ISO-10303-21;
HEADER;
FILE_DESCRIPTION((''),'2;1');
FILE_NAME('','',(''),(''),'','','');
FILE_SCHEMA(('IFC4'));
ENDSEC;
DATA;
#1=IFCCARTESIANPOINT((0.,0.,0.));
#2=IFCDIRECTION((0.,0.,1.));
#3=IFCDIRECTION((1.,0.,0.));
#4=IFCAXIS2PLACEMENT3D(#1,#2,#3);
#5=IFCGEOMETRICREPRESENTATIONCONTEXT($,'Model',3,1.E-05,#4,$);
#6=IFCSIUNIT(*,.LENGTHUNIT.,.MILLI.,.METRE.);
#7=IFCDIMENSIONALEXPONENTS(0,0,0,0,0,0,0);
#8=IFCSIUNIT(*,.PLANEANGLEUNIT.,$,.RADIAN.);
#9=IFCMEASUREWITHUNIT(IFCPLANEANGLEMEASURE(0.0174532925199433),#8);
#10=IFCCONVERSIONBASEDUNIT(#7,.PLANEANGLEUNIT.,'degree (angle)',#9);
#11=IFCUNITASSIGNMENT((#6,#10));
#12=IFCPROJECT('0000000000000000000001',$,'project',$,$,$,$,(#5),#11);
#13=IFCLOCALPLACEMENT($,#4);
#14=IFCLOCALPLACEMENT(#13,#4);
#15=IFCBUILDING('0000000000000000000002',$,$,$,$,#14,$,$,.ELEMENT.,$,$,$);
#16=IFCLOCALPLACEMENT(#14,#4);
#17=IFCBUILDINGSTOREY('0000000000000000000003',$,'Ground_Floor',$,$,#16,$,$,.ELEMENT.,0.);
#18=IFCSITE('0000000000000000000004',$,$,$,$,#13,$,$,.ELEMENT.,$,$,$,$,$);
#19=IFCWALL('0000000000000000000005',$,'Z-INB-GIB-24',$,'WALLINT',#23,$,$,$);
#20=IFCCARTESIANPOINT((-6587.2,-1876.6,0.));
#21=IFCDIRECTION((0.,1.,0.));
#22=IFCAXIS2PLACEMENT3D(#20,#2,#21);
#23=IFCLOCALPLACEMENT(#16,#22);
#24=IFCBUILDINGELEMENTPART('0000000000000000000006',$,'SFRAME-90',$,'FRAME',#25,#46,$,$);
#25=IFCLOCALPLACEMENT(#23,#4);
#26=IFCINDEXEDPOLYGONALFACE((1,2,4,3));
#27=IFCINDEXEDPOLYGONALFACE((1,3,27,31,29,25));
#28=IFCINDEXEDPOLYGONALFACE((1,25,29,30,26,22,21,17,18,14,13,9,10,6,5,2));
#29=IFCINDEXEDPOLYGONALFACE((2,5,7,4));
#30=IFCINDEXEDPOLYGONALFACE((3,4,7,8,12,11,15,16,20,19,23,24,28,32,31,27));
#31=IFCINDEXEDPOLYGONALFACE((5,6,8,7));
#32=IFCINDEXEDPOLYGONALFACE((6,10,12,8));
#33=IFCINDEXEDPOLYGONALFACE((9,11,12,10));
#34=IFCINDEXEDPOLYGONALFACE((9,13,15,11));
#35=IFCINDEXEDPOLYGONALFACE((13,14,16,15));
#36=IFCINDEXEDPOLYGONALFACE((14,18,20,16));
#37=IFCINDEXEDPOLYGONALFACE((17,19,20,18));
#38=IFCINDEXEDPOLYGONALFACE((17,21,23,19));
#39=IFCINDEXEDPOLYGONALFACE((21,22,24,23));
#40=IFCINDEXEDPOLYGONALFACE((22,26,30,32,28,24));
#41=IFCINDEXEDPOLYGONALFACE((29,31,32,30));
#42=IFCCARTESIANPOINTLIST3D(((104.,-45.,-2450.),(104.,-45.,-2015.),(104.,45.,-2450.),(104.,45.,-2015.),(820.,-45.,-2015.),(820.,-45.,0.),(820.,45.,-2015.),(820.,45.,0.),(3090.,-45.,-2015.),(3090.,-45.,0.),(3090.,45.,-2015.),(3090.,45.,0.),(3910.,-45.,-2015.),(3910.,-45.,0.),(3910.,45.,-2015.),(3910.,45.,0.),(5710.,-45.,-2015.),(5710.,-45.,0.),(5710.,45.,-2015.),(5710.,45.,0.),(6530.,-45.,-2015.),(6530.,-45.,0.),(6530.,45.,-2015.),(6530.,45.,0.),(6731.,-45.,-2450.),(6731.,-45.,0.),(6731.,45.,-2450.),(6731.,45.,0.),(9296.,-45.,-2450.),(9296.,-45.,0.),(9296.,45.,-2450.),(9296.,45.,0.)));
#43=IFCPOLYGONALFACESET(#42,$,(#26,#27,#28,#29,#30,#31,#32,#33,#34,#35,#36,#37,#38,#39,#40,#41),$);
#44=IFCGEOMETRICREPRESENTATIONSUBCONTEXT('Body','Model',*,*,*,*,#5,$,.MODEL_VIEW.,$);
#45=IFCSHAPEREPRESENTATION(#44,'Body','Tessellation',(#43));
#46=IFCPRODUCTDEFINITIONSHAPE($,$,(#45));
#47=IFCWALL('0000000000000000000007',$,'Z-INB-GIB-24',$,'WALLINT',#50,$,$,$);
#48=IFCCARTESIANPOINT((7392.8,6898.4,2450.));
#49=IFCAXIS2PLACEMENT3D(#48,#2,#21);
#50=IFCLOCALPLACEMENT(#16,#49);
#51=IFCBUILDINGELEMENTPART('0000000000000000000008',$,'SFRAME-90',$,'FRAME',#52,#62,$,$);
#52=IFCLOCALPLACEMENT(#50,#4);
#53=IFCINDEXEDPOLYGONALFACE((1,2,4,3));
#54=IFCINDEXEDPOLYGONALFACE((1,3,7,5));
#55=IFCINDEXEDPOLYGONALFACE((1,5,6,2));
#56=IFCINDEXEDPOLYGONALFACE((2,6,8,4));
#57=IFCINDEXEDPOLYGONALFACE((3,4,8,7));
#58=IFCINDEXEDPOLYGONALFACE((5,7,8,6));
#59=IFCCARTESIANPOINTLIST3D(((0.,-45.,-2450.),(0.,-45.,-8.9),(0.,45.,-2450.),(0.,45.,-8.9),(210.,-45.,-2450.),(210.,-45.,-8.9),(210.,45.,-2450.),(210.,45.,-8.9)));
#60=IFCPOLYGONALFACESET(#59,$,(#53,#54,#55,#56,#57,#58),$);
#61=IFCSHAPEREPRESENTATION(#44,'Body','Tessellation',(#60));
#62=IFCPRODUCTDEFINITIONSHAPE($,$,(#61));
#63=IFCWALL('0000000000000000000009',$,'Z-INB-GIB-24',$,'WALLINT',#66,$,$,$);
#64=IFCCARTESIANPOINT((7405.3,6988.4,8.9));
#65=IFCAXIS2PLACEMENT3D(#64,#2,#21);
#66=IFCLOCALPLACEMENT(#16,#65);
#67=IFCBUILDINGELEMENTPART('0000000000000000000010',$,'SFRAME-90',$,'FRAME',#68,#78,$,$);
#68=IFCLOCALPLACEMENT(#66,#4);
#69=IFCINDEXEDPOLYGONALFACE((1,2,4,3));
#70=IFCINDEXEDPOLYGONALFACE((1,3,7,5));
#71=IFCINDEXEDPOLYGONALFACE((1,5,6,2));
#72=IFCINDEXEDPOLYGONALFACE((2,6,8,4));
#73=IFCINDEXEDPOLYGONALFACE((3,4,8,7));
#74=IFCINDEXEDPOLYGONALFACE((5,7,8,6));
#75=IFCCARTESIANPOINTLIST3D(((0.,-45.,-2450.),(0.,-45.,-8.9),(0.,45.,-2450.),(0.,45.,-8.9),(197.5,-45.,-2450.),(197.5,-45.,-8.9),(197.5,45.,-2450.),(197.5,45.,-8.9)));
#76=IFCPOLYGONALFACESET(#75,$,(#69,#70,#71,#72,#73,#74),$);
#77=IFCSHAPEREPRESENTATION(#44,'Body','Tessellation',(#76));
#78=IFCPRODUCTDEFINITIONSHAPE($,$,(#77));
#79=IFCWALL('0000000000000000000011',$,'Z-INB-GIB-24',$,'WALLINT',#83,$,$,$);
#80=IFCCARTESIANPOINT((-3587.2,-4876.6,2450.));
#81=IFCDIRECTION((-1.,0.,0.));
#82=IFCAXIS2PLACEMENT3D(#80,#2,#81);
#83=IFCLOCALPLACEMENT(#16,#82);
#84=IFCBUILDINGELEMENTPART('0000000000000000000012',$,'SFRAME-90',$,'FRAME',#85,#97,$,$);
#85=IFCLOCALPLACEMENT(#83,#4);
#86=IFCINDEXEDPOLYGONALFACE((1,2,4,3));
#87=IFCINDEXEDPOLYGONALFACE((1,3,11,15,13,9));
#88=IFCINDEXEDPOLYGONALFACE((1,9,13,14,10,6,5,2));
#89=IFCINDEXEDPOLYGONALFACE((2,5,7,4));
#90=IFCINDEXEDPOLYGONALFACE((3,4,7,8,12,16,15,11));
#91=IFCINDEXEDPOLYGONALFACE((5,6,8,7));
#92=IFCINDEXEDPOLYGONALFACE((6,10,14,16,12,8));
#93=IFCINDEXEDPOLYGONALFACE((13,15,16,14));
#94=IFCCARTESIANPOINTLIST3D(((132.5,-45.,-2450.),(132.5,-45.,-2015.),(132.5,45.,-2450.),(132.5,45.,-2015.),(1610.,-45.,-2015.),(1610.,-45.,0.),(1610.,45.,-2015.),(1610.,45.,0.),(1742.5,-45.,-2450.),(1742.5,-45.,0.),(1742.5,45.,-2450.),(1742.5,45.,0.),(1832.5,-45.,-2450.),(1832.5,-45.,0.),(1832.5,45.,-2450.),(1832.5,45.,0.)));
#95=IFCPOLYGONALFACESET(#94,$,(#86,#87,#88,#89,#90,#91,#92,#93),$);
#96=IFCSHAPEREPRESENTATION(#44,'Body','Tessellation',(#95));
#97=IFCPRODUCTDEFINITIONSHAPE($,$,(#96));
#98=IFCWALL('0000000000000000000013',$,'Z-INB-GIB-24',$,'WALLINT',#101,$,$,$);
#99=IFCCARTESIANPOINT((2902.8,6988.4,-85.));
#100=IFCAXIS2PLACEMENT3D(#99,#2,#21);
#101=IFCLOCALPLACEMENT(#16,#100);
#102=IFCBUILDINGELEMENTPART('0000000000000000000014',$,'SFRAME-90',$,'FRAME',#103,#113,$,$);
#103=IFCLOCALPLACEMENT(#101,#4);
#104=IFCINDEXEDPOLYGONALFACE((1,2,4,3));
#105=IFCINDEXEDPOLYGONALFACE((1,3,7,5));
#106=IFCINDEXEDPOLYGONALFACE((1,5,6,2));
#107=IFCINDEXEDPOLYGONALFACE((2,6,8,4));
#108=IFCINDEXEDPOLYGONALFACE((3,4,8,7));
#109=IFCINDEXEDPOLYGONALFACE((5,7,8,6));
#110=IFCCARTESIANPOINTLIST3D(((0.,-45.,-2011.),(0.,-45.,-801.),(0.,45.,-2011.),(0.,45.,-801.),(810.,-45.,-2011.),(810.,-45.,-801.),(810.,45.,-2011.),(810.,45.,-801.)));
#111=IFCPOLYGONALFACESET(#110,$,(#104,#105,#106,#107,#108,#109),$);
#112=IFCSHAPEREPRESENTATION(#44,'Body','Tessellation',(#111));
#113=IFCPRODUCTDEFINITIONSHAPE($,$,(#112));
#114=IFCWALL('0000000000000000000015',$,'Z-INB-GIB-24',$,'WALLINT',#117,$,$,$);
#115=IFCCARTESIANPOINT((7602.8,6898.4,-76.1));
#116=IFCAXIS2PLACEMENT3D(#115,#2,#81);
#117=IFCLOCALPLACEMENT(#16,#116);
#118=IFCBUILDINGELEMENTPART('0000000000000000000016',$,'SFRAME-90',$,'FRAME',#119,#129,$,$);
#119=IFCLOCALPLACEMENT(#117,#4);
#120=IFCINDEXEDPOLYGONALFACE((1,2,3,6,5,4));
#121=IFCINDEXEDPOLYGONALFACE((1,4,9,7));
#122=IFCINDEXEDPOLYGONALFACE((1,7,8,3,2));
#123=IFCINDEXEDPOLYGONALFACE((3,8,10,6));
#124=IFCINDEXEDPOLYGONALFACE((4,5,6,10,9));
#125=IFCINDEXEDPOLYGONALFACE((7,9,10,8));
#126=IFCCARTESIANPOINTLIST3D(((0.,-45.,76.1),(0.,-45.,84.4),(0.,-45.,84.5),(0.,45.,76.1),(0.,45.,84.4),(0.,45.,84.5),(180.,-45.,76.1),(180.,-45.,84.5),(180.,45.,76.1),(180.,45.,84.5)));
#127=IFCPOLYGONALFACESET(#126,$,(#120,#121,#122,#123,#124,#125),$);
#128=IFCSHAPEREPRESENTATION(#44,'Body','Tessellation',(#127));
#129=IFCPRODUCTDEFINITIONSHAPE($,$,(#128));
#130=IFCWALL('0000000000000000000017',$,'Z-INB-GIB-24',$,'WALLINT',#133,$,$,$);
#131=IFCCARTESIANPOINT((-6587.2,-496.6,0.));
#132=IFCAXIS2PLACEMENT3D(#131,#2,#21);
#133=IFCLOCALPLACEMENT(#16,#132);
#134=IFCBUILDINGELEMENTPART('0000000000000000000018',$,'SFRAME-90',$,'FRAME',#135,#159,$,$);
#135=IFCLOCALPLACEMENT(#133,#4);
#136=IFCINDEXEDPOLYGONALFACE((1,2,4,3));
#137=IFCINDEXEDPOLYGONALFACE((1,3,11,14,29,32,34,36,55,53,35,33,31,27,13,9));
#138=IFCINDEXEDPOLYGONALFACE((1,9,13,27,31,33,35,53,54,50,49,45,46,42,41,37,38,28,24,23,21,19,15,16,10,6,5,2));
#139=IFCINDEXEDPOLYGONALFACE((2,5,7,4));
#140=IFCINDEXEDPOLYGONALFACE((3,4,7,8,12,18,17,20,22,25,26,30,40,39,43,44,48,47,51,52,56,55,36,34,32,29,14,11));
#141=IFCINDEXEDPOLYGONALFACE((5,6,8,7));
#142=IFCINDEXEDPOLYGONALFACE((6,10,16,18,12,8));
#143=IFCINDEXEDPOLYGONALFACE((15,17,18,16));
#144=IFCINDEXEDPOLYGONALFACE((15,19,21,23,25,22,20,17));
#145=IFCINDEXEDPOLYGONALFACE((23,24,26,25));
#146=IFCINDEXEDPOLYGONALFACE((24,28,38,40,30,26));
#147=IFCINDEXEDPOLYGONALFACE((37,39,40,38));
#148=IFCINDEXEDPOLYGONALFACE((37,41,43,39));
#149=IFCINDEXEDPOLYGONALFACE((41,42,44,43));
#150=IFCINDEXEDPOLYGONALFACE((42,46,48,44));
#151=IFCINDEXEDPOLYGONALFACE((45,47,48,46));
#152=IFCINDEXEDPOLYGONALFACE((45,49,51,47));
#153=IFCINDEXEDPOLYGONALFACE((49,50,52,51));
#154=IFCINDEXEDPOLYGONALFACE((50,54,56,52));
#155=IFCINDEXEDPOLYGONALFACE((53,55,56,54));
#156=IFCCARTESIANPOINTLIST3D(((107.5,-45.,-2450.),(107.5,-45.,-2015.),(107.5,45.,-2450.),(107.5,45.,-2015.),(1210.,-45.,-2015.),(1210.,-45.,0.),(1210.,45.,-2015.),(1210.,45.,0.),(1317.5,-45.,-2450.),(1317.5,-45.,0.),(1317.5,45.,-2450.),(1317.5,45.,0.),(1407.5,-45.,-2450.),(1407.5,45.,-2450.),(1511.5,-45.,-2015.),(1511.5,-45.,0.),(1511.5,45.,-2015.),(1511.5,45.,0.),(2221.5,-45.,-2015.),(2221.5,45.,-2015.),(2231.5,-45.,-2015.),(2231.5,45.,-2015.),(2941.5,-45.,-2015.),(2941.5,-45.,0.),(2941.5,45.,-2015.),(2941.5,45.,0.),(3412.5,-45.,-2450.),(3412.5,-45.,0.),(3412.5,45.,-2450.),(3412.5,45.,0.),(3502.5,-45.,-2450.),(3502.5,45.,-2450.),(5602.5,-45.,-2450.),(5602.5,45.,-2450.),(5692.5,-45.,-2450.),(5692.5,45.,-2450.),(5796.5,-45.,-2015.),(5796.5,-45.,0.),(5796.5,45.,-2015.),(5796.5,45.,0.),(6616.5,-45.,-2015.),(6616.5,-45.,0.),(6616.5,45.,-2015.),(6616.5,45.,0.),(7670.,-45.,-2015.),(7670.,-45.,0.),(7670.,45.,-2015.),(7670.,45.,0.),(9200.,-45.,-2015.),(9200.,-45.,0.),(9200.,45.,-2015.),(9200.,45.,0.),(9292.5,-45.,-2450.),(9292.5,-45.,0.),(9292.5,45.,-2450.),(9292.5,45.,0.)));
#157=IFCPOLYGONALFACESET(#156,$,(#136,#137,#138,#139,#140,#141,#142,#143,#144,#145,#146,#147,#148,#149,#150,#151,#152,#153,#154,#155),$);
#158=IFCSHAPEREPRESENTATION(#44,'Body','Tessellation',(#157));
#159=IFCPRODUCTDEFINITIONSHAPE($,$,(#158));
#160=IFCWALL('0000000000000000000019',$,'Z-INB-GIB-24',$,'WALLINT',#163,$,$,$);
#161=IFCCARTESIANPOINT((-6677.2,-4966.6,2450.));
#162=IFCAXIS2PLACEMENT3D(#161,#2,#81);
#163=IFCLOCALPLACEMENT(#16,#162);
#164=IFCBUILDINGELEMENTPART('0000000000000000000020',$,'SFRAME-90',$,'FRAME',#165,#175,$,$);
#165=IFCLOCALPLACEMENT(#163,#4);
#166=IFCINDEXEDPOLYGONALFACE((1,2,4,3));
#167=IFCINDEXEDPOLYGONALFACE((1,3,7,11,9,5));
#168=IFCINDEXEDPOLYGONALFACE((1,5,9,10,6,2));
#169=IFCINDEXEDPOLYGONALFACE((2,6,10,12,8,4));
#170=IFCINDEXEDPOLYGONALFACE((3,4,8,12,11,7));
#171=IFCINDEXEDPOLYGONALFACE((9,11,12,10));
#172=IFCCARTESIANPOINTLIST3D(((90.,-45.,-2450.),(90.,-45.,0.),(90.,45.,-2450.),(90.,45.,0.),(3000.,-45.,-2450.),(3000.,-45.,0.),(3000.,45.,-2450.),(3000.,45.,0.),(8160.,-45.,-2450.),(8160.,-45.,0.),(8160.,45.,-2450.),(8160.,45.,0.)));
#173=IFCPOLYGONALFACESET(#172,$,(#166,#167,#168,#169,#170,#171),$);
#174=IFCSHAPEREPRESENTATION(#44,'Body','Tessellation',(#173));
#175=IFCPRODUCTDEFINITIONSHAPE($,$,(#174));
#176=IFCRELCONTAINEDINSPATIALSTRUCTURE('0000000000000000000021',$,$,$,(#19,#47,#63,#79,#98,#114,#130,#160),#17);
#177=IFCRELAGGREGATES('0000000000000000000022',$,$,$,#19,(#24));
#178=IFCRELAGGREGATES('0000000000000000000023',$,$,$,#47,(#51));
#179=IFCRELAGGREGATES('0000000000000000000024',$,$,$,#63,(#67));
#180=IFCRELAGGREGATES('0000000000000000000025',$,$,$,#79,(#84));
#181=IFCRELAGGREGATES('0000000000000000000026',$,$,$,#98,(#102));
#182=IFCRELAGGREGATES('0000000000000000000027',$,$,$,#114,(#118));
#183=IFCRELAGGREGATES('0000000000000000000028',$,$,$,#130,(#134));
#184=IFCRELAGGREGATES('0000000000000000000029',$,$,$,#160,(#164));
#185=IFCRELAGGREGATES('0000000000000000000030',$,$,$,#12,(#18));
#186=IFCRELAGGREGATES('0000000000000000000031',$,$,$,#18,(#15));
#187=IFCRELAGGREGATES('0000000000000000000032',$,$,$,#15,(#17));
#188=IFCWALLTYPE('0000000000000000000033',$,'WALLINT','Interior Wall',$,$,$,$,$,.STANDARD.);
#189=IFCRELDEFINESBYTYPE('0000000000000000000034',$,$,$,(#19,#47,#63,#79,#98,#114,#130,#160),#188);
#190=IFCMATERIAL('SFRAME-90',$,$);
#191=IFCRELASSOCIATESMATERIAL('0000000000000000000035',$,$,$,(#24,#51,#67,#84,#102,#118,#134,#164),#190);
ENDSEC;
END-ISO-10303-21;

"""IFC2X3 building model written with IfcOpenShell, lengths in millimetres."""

from ifc_helpers import new_model, entity, si_unit, converted_unit, frame, origin_with_axes, place, context, subcontext, project, spatial, polyline, segment, composite_curve, outline, extrude, material, type_object, element, aggregate, save


model = new_model("IFC2X3")

# Units and contexts
model_context = context("Model", 3, precision=1e-05, world=origin_with_axes())
body_context = subcontext(model_context, "Body", "Model", "MODEL_VIEW")
ifc_project = project(units=[si_unit("LENGTHUNIT", "METRE", prefix="MILLI"), converted_unit("PLANEANGLEUNIT", "degree (angle)", entity("IfcPlaneAngleMeasure", 0.0174532925199433), si_unit("PLANEANGLEUNIT", "RADIAN"), dimensions=[0, 0, 0, 0, 0, 0, 0])], contexts=[model_context])

# Site, building, storey
site_placement = place(None, origin_with_axes())
site = spatial("IfcSite", under=ifc_project, at=site_placement, CompositionType="ELEMENT")
building_placement = place(site_placement, origin_with_axes())
building = spatial("IfcBuilding", under=site, at=building_placement, CompositionType="ELEMENT")
storey_placement = place(building_placement, origin_with_axes())
storey = spatial("IfcBuildingStorey", under=building, at=storey_placement, Name="Ground_Floor", CompositionType="ELEMENT", Elevation=0.0)

# Walls, building element parts
wall_type = type_object("IfcWallType", Name="WALLINT", Description="Interior Wall", PredefinedType="STANDARD")
ifc_material = material(Name="SFRAME-90")
wall_1_placement = place(storey_placement, frame((-6587.2, -1876.6, 0.0), z_axis=(0.0, 0.0, 1.0), x_axis=(0.0, 1.0, 0.0)))
wall_1 = element("IfcWall", 1, at=wall_1_placement, inside=storey, type_object=wall_type, Name="Z-INB-GIB-24", ObjectType="WALLINT")
building_element_part_1_placement = place(wall_1_placement, origin_with_axes())
building_element_part_1 = element("IfcBuildingElementPart", 2, at=building_element_part_1_placement, material=ifc_material, Name="SFRAME-90", ObjectType="FRAME", context=body_context, shape_type="SweptSolid", body=[
    extrude(outline(composite_curve([segment(polyline([(0.0, 0.0), (0.0, 2015.0), (820.0, 2015.0), (820.0, 0.0), (3090.0, 0.0), (3090.0, 2015.0), (3910.0, 2015.0), (3910.0, 0.0), (5710.0, 0.0), (5710.0, 2015.0), (6530.0, 2015.0), (6530.0, 0.0), (6731.0, 0.0), (9296.0, 0.0), (9296.0, 2450.0), (6731.0, 2450.0), (104.0, 2450.0), (104.0, 0.0), (0.0, 0.0)]), True, "CONTINUOUS")], self_intersect=False)), frame((0.0, -45.0, 0.0), z_axis=(0.0, 1.0, 0.0), x_axis=(1.0, 0.0, 0.0)), (0.0, 0.0, 1.0), 90.0),
])
aggregate(wall_1, [building_element_part_1])
wall_2_placement = place(storey_placement, frame((7392.8, 6898.4, 2450.0), z_axis=(0.0, 0.0, 1.0), x_axis=(0.0, 1.0, 0.0)))
wall_2 = element("IfcWall", 3, at=wall_2_placement, inside=storey, type_object=wall_type, Name="Z-INB-GIB-24", ObjectType="WALLINT")
building_element_part_2_placement = place(wall_2_placement, origin_with_axes())
building_element_part_2 = element("IfcBuildingElementPart", 4, at=building_element_part_2_placement, material=ifc_material, Name="SFRAME-90", ObjectType="FRAME", context=body_context, shape_type="SweptSolid", body=[
    extrude(outline(composite_curve([segment(polyline([(0.0, 8.9), (210.0, 8.9), (210.0, 2450.0), (0.0, 2450.0), (0.0, 8.9)]), True, "CONTINUOUS")], self_intersect=False)), frame((0.0, -45.0, 0.0), z_axis=(0.0, 1.0, 0.0), x_axis=(1.0, 0.0, 0.0)), (0.0, 0.0, 1.0), 90.0),
])
aggregate(wall_2, [building_element_part_2])
wall_3_placement = place(storey_placement, frame((7405.3, 6988.4, 8.9), z_axis=(0.0, 0.0, 1.0), x_axis=(0.0, 1.0, 0.0)))
wall_3 = element("IfcWall", 5, at=wall_3_placement, inside=storey, type_object=wall_type, Name="Z-INB-GIB-24", ObjectType="WALLINT")
building_element_part_3_placement = place(wall_3_placement, origin_with_axes())
building_element_part_3 = element("IfcBuildingElementPart", 6, at=building_element_part_3_placement, material=ifc_material, Name="SFRAME-90", ObjectType="FRAME", context=body_context, shape_type="SweptSolid", body=[
    extrude(outline(composite_curve([segment(polyline([(0.0, 2450.0), (0.0, 8.9), (197.5, 8.9), (197.5, 2450.0), (0.0, 2450.0)]), True, "CONTINUOUS")], self_intersect=False)), frame((0.0, -45.0, 0.0), z_axis=(0.0, 1.0, 0.0), x_axis=(1.0, 0.0, 0.0)), (0.0, 0.0, 1.0), 90.0),
])
aggregate(wall_3, [building_element_part_3])
wall_4_placement = place(storey_placement, frame((-3587.2, -4876.6, 2450.0), z_axis=(0.0, 0.0, 1.0), x_axis=(-1.0, 0.0, 0.0)))
wall_4 = element("IfcWall", 7, at=wall_4_placement, inside=storey, type_object=wall_type, Name="Z-INB-GIB-24", ObjectType="WALLINT")
building_element_part_4_placement = place(wall_4_placement, origin_with_axes())
building_element_part_4 = element("IfcBuildingElementPart", 8, at=building_element_part_4_placement, material=ifc_material, Name="SFRAME-90", ObjectType="FRAME", context=body_context, shape_type="SweptSolid", body=[
    extrude(outline(composite_curve([segment(polyline([(0.0, 0.0), (0.0, 2015.0), (1610.0, 2015.0), (1610.0, 0.0), (1742.5, 0.0), (1832.5, 0.0), (1832.5, 2450.0), (1742.5, 2450.0), (132.5, 2450.0), (132.5, 0.0), (0.0, 0.0)]), True, "CONTINUOUS")], self_intersect=False)), frame((0.0, -45.0, 0.0), z_axis=(0.0, 1.0, 0.0), x_axis=(1.0, 0.0, 0.0)), (0.0, 0.0, 1.0), 90.0),
])
aggregate(wall_4, [building_element_part_4])
wall_5_placement = place(storey_placement, frame((2902.8, 6988.4, -85.0), z_axis=(0.0, 0.0, 1.0), x_axis=(0.0, 1.0, 0.0)))
wall_5 = element("IfcWall", 9, at=wall_5_placement, inside=storey, type_object=wall_type, Name="Z-INB-GIB-24", ObjectType="WALLINT")
building_element_part_5_placement = place(wall_5_placement, origin_with_axes())
building_element_part_5 = element("IfcBuildingElementPart", 10, at=building_element_part_5_placement, material=ifc_material, Name="SFRAME-90", ObjectType="FRAME", context=body_context, shape_type="SweptSolid", body=[
    extrude(outline(composite_curve([segment(polyline([(0.0, 2011.0), (0.0, 801.0), (810.0, 801.0), (810.0, 2011.0), (0.0, 2011.0)]), True, "CONTINUOUS")], self_intersect=False)), frame((0.0, -45.0, 0.0), z_axis=(0.0, 1.0, 0.0), x_axis=(1.0, 0.0, 0.0)), (0.0, 0.0, 1.0), 90.0),
])
aggregate(wall_5, [building_element_part_5])
wall_6_placement = place(storey_placement, frame((7602.8, 6898.4, -76.1), z_axis=(0.0, 0.0, 1.0), x_axis=(-1.0, 0.0, 0.0)))
wall_6 = element("IfcWall", 11, at=wall_6_placement, inside=storey, type_object=wall_type, Name="Z-INB-GIB-24", ObjectType="WALLINT")
building_element_part_6_placement = place(wall_6_placement, origin_with_axes())
building_element_part_6 = element("IfcBuildingElementPart", 12, at=building_element_part_6_placement, material=ifc_material, Name="SFRAME-90", ObjectType="FRAME", context=body_context, shape_type="SweptSolid", body=[
    extrude(outline(composite_curve([segment(polyline([(0.0, -76.1), (180.0, -76.1), (180.0, -84.5), (0.0, -84.5), (0.0, -84.4), (0.0, -76.1)]), True, "CONTINUOUS")], self_intersect=False)), frame((0.0, -45.0, 0.0), z_axis=(0.0, 1.0, 0.0), x_axis=(1.0, 0.0, 0.0)), (0.0, 0.0, 1.0), 90.0),
])
aggregate(wall_6, [building_element_part_6])
wall_7_placement = place(storey_placement, frame((-6587.2, -496.6, 0.0), z_axis=(0.0, 0.0, 1.0), x_axis=(0.0, 1.0, 0.0)))
wall_7 = element("IfcWall", 13, at=wall_7_placement, inside=storey, type_object=wall_type, Name="Z-INB-GIB-24", ObjectType="WALLINT")
building_element_part_7_placement = place(wall_7_placement, origin_with_axes())
building_element_part_7 = element("IfcBuildingElementPart", 14, at=building_element_part_7_placement, material=ifc_material, Name="SFRAME-90", ObjectType="FRAME", context=body_context, shape_type="SweptSolid", body=[
    extrude(outline(composite_curve([segment(polyline([(0.0, 0.0), (0.0, 2015.0), (1210.0, 2015.0), (1210.0, 0.0), (1317.5, 0.0), (1511.5, 0.0), (1511.5, 2015.0), (2221.5, 2015.0), (2231.5, 2015.0), (2941.5, 2015.0), (2941.5, 0.0), (3412.5, 0.0), (5796.5, 0.0), (5796.5, 2015.0), (6616.5, 2015.0), (6616.5, 0.0), (7670.0, 0.0), (7670.0, 2015.0), (9200.0, 2015.0), (9200.0, 0.0), (9292.5, 0.0), (9292.5, 2450.0), (5692.5, 2450.0), (5602.5, 2450.0), (3502.5, 2450.0), (3412.5, 2450.0), (1407.5, 2450.0), (1317.5, 2450.0), (107.5, 2450.0), (107.5, 0.0), (0.0, 0.0)]), True, "CONTINUOUS")], self_intersect=False)), frame((0.0, -45.0, 0.0), z_axis=(0.0, 1.0, 0.0), x_axis=(1.0, 0.0, 0.0)), (0.0, 0.0, 1.0), 90.0),
])
aggregate(wall_7, [building_element_part_7])
wall_8_placement = place(storey_placement, frame((-6677.2, -4966.6, 2450.0), z_axis=(0.0, 0.0, 1.0), x_axis=(-1.0, 0.0, 0.0)))
wall_8 = element("IfcWall", 15, at=wall_8_placement, inside=storey, type_object=wall_type, Name="Z-INB-GIB-24", ObjectType="WALLINT")
building_element_part_8_placement = place(wall_8_placement, origin_with_axes())
building_element_part_8 = element("IfcBuildingElementPart", 16, at=building_element_part_8_placement, material=ifc_material, Name="SFRAME-90", ObjectType="FRAME", context=body_context, shape_type="SweptSolid", body=[
    extrude(outline(composite_curve([segment(polyline([(0.0, 2450.0), (90.0, 2450.0), (90.0, 0.0), (0.0, 0.0), (3000.0, 0.0), (8160.0, 0.0), (8160.0, 2450.0), (3000.0, 2450.0), (0.0, 2450.0)]), True, "CONTINUOUS")], self_intersect=False)), frame((0.0, -45.0, 0.0), z_axis=(0.0, 1.0, 0.0), x_axis=(1.0, 0.0, 0.0)), (0.0, 0.0, 1.0), 90.0),
])
aggregate(wall_8, [building_element_part_8])

save(model, "model.ifc")
